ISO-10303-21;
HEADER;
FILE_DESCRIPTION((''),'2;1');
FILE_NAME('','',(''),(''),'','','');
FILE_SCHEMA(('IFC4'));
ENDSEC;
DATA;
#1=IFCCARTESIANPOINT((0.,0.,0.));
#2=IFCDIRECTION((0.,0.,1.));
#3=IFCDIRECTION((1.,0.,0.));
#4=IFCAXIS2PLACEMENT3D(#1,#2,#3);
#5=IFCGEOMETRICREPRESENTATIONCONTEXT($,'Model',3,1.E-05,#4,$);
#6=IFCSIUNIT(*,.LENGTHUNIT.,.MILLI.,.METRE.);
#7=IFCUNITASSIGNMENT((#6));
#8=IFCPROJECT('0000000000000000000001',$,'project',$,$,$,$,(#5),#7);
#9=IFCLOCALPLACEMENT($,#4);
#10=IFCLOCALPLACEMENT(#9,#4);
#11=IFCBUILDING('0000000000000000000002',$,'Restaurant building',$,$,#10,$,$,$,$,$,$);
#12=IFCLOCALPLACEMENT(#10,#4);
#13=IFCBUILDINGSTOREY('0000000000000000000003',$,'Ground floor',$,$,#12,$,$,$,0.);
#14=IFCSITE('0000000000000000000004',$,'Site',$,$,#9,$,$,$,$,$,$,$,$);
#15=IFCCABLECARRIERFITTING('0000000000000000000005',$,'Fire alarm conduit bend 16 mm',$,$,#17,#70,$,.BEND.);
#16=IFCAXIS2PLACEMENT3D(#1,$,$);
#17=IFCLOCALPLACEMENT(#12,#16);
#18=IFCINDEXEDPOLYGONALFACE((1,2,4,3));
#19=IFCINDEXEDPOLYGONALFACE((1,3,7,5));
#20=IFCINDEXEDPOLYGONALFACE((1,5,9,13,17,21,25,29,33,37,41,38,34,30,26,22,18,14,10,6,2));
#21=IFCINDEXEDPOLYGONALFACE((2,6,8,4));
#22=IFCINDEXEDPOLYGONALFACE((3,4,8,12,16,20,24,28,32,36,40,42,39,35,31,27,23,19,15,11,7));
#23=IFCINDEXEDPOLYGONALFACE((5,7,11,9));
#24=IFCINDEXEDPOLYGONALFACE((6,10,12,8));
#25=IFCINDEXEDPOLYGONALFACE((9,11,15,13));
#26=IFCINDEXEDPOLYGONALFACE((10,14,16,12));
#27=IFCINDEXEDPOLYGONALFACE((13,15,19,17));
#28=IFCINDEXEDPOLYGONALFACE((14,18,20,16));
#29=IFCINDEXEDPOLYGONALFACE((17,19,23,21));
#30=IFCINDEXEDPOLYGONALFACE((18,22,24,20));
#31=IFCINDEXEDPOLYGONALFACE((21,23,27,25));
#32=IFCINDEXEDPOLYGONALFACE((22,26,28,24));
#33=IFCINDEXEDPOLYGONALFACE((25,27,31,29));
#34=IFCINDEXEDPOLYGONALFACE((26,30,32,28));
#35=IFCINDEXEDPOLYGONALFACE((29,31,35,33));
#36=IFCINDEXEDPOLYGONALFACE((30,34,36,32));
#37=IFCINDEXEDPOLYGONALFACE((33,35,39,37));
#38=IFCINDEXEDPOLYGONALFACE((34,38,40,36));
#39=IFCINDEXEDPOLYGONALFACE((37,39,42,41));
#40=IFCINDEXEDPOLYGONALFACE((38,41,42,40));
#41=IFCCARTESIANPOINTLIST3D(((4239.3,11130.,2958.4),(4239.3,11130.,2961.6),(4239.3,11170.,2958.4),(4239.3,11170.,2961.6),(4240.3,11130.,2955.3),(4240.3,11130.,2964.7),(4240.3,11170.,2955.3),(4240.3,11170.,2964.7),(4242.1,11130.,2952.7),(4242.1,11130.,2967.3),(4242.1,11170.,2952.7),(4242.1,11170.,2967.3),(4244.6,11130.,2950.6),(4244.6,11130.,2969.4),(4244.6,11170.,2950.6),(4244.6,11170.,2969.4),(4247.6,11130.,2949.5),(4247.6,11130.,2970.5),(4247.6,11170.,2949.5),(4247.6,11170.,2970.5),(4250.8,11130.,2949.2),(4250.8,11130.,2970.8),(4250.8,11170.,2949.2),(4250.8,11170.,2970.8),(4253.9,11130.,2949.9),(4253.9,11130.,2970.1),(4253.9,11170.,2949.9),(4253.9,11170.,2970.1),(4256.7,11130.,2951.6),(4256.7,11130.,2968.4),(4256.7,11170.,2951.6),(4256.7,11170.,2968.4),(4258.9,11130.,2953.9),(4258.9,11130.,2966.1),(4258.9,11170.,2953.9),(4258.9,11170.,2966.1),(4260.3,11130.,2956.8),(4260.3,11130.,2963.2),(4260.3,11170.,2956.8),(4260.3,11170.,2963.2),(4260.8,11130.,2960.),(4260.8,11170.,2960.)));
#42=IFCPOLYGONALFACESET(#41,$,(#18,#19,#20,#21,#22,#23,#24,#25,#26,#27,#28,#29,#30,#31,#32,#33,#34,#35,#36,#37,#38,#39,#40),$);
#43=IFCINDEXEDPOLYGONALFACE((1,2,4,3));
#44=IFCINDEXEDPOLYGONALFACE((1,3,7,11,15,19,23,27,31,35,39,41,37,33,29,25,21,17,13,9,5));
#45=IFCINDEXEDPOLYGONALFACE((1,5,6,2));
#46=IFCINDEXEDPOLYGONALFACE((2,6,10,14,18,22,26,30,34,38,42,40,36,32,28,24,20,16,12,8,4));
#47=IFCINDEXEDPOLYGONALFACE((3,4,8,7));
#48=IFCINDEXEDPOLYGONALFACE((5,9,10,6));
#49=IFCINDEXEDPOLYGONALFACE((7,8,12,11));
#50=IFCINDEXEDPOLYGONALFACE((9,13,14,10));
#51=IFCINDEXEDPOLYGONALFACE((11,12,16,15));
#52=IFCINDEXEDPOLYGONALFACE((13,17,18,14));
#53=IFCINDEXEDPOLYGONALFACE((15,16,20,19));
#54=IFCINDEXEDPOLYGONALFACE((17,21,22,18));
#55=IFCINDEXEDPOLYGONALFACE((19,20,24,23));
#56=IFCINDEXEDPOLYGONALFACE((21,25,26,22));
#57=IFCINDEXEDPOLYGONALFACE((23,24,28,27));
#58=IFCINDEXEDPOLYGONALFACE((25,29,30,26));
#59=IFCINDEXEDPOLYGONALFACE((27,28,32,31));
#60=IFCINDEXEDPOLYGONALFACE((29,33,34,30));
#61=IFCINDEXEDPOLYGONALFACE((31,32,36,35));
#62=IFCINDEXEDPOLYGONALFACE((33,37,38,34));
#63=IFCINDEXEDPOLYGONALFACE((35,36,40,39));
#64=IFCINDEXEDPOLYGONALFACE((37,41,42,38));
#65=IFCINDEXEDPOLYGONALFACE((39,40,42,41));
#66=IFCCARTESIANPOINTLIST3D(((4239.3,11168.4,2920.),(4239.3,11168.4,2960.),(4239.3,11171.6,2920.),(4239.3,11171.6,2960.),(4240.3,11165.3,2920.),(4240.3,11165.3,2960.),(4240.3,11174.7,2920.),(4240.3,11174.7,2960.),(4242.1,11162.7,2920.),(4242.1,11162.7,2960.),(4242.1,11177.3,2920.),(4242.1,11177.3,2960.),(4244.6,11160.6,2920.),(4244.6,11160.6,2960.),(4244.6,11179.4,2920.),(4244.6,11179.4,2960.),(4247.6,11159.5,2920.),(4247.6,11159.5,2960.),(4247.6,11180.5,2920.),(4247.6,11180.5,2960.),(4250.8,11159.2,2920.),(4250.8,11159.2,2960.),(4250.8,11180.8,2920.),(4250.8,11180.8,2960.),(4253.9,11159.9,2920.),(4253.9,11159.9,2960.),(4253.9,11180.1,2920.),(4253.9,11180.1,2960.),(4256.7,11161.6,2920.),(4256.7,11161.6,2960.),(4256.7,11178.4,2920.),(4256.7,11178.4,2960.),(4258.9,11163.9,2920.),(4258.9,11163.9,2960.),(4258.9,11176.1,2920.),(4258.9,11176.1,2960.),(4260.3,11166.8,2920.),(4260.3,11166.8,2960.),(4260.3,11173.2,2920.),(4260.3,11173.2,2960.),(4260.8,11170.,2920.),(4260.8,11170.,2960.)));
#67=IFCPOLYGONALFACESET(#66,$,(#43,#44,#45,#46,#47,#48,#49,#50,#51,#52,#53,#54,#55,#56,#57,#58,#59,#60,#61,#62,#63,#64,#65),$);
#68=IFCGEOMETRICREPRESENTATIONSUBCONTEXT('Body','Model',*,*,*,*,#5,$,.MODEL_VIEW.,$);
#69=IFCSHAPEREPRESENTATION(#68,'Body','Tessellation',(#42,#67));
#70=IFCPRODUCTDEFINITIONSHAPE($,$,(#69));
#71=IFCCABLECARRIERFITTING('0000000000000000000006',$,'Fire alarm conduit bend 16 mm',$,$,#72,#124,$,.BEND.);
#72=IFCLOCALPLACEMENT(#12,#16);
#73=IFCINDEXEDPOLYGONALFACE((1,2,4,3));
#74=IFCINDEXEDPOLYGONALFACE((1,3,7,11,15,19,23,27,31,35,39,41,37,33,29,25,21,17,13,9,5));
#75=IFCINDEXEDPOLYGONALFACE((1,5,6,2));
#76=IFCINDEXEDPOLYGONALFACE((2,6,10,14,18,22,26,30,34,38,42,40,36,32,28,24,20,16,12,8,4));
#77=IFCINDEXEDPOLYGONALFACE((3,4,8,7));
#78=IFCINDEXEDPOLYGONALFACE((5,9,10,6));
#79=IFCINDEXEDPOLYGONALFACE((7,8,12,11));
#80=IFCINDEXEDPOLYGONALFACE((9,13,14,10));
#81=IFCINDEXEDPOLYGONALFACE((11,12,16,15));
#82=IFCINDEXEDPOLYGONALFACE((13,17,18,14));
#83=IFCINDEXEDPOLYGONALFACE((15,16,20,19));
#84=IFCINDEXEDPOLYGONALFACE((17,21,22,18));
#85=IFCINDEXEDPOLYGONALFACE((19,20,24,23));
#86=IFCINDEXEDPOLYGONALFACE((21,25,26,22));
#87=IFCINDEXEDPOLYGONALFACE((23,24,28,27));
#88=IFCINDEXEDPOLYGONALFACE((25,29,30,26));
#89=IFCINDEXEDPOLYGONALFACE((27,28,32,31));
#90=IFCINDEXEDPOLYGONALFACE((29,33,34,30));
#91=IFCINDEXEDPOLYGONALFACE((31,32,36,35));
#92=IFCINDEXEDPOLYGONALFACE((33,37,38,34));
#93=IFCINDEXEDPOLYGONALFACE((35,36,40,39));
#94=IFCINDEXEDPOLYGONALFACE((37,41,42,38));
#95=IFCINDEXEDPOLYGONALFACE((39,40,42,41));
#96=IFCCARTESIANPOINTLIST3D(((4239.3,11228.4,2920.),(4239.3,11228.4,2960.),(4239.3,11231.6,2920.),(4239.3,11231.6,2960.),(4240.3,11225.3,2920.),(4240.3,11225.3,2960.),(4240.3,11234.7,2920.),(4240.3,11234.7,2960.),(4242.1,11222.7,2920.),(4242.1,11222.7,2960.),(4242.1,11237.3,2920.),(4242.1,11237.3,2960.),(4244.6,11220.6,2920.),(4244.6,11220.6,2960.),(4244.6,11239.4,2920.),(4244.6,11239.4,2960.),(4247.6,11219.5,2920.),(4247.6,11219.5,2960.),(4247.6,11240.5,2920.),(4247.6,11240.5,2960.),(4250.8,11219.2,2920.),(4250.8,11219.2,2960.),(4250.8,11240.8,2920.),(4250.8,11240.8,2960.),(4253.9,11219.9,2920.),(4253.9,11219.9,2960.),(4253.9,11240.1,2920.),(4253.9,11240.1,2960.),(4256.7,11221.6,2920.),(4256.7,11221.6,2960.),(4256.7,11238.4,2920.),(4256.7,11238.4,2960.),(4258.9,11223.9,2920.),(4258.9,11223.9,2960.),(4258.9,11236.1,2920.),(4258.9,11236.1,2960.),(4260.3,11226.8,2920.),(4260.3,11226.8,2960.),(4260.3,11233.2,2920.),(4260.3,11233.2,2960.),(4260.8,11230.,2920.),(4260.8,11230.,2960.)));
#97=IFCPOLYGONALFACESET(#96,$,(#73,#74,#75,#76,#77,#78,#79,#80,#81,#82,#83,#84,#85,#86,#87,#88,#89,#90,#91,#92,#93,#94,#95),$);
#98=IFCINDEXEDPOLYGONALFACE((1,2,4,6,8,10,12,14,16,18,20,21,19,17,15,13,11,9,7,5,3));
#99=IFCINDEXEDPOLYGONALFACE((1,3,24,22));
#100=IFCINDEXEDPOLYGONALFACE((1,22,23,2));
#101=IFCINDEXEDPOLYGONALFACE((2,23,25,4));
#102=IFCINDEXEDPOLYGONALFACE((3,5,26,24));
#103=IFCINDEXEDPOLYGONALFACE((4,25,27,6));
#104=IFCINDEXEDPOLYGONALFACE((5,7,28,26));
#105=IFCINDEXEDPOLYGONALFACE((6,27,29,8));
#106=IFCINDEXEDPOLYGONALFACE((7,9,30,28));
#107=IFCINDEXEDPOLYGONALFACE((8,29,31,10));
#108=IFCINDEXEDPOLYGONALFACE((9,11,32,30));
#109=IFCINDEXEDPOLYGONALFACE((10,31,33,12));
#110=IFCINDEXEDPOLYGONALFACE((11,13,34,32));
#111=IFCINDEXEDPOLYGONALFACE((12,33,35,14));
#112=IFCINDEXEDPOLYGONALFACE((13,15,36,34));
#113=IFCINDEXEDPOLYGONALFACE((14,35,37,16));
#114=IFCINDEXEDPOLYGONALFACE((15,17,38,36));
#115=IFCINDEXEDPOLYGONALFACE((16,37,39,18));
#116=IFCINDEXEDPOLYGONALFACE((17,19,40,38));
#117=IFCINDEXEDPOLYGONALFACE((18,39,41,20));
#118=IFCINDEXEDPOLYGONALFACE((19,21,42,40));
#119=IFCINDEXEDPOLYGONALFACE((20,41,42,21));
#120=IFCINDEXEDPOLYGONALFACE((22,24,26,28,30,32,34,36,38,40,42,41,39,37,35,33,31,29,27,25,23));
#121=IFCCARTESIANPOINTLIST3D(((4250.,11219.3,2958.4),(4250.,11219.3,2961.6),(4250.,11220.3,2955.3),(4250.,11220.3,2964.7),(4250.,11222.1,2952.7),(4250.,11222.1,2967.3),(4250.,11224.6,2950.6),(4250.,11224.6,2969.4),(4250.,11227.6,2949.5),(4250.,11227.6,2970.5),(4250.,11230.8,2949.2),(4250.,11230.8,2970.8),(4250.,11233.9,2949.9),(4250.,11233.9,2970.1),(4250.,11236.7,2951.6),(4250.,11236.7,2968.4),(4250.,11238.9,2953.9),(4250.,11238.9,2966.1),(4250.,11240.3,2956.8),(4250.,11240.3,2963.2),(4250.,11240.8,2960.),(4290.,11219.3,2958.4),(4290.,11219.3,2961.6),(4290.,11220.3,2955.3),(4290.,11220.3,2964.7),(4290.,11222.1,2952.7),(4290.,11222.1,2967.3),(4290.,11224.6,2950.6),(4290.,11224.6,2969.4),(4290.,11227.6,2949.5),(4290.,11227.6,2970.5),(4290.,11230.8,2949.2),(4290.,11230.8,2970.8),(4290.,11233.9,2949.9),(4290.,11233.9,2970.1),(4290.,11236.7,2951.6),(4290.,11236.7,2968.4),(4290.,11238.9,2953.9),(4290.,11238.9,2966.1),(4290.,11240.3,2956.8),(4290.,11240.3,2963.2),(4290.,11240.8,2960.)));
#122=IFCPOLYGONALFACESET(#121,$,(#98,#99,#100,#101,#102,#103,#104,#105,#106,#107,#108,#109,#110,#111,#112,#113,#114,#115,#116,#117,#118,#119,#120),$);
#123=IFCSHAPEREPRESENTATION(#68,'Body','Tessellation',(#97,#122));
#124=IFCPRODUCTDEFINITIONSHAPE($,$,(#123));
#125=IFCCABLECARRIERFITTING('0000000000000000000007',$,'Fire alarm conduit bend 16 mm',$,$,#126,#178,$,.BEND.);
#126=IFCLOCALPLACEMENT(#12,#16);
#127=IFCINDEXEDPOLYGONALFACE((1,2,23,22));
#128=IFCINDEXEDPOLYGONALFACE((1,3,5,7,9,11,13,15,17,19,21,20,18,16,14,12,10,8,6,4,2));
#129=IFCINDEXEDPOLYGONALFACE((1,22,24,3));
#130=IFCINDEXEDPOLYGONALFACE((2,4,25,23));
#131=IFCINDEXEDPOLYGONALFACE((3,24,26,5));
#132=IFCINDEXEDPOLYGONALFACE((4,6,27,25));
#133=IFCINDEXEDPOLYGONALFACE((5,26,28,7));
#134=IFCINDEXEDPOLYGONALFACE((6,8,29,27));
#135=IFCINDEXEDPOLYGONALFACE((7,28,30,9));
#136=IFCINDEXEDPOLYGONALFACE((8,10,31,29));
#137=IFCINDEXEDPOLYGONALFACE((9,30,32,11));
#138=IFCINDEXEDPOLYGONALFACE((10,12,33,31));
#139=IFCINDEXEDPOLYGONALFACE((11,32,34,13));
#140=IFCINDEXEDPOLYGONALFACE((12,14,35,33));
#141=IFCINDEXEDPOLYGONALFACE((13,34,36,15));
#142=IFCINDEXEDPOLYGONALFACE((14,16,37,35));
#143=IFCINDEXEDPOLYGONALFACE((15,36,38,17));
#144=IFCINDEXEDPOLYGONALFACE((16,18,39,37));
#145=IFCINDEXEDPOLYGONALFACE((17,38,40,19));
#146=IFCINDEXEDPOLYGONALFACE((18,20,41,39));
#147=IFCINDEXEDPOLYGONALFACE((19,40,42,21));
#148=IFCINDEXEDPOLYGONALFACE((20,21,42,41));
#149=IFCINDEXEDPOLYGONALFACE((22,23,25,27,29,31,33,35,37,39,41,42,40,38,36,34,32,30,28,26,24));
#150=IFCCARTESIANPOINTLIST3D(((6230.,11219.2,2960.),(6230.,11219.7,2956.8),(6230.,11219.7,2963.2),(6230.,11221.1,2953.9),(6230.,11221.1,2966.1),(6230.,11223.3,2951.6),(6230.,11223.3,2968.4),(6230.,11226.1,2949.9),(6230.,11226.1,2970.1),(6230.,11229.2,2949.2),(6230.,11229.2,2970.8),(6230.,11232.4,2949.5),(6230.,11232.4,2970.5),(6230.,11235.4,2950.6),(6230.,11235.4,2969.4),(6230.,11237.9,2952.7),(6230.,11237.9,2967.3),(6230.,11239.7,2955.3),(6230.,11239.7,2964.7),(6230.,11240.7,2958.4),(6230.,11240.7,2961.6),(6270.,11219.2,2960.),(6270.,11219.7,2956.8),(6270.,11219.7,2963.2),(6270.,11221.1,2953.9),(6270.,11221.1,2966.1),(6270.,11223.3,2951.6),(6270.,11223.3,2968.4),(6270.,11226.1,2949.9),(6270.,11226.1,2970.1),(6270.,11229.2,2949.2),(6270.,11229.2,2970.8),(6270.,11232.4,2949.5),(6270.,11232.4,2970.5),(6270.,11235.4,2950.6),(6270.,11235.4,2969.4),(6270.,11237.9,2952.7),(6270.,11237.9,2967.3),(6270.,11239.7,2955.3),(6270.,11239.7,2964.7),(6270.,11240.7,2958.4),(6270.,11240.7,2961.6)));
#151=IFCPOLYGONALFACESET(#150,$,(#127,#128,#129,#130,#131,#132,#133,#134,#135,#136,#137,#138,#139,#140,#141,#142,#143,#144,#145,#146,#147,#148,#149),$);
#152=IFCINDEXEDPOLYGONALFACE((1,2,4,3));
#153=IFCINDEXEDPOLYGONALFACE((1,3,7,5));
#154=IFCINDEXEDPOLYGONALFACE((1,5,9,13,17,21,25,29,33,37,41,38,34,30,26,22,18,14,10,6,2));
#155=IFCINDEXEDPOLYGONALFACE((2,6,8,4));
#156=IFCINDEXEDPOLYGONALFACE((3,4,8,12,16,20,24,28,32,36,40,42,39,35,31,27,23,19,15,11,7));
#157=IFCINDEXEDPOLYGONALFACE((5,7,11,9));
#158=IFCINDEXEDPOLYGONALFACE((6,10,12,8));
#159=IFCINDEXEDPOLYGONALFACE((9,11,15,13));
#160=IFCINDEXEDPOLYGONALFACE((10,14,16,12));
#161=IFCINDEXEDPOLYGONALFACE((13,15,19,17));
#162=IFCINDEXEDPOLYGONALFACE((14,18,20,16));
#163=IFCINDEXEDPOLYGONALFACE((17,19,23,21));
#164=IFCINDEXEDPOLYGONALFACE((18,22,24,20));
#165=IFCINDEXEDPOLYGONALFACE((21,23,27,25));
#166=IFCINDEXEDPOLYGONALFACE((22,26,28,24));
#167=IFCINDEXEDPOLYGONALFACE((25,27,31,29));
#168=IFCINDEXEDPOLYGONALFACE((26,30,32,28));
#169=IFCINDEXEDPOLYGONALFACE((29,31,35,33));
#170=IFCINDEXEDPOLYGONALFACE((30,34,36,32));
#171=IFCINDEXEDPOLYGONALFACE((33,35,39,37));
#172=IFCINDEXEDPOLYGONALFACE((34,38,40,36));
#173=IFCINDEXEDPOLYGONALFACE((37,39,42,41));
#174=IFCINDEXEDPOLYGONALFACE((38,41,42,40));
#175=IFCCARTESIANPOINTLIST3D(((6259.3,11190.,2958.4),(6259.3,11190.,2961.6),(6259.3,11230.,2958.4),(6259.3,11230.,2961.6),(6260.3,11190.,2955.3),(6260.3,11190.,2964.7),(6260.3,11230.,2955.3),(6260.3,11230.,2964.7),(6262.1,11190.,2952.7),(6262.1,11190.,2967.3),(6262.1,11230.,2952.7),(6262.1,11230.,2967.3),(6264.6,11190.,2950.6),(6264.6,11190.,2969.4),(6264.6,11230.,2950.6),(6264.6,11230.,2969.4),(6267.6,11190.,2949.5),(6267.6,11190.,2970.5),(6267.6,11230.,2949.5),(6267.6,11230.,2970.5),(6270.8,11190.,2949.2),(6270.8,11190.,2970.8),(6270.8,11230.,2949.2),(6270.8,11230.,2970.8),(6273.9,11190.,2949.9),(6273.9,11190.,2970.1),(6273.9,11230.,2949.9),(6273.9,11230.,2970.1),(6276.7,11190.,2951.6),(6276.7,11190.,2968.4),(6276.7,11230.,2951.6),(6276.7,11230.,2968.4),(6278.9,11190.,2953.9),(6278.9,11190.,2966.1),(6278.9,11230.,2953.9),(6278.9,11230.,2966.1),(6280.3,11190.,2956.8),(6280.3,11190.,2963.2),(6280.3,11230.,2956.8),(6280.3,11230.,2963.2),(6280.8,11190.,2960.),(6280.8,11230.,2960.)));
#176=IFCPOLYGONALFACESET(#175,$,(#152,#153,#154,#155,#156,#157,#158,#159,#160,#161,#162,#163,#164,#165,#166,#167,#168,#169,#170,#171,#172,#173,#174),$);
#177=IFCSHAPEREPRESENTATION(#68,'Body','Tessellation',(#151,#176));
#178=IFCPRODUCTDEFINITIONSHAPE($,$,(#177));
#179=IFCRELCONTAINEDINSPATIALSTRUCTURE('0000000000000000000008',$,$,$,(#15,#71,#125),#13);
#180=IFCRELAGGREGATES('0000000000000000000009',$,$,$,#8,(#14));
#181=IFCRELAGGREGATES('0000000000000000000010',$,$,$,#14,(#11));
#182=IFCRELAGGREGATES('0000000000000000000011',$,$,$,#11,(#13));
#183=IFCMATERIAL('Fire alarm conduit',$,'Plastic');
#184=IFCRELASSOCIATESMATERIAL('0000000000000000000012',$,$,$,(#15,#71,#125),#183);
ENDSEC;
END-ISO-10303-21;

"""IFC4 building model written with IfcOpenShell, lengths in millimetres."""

from ifc_helpers import new_model, si_unit, frame, origin_with_axes, origin_2d, place, context, subcontext, project, spatial, circle, extrude, material, element, save


model = new_model("IFC4")

# Units and contexts
model_context = context("Model", 3, precision=1e-05, world=origin_with_axes())
body_context = subcontext(model_context, "Body", "Model", "MODEL_VIEW")
ifc_project = project(units=[si_unit("LENGTHUNIT", "METRE", prefix="MILLI")], contexts=[model_context])

# Site, building, storey
site_placement = place(None, origin_with_axes())
site = spatial("IfcSite", under=ifc_project, at=site_placement, Name="Site")
building_placement = place(site_placement, origin_with_axes())
building = spatial("IfcBuilding", under=site, at=building_placement, Name="Restaurant building")
storey_placement = place(building_placement, origin_with_axes())
storey = spatial("IfcBuildingStorey", under=building, at=storey_placement, Name="Ground floor", Elevation=0.0)

# Shared definitions
ifc_material_1 = material(Name="Fire alarm conduit", Category="Plastic")

# Cable carrier fittings
cable_carrier_fitting_1_placement = place(storey_placement, frame((4250.0, 11170.0, 2960.0)))
element("IfcCableCarrierFitting", 1, at=cable_carrier_fitting_1_placement, inside=storey, material=ifc_material_1, Name="Fire alarm conduit bend 16 mm", PredefinedType="BEND", context=body_context, shape_type="SweptSolid", body=[
    extrude(circle(Radius=10.8, at=origin_2d()), frame((0.0, 0.0, 0.0), z_axis=(0.0, -1.0, 0.0), x_axis=(1.0, 0.0, 0.0)), (0.0, 0.0, 1.0), 40.0),
    extrude(circle(Radius=10.8, at=origin_2d()), frame((0.0, 0.0, 0.0), z_axis=(0.0, 0.0, -1.0), x_axis=(1.0, 0.0, 0.0)), (0.0, 0.0, 1.0), 40.0),
])
cable_carrier_fitting_2_placement = place(storey_placement, frame((4250.0, 11230.0, 2960.0)))
element("IfcCableCarrierFitting", 2, at=cable_carrier_fitting_2_placement, inside=storey, material=ifc_material_1, Name="Fire alarm conduit bend 16 mm", PredefinedType="BEND", context=body_context, shape_type="SweptSolid", body=[
    extrude(circle(Radius=10.8, at=origin_2d()), frame((0.0, 0.0, 0.0), z_axis=(0.0, 0.0, -1.0), x_axis=(1.0, 0.0, 0.0)), (0.0, 0.0, 1.0), 40.0),
    extrude(circle(Radius=10.8, at=origin_2d()), frame((0.0, 0.0, 0.0), z_axis=(1.0, 0.0, 0.0), x_axis=(0.0, 1.0, 0.0)), (0.0, 0.0, 1.0), 40.0),
])
cable_carrier_fitting_3_placement = place(storey_placement, frame((6270.0, 11230.0, 2960.0)))
element("IfcCableCarrierFitting", 3, at=cable_carrier_fitting_3_placement, inside=storey, material=ifc_material_1, Name="Fire alarm conduit bend 16 mm", PredefinedType="BEND", context=body_context, shape_type="SweptSolid", body=[
    extrude(circle(Radius=10.8, at=origin_2d()), frame((0.0, 0.0, 0.0), z_axis=(-1.0, 0.0, 0.0), x_axis=(0.0, -1.0, 0.0)), (0.0, 0.0, 1.0), 40.0),
    extrude(circle(Radius=10.8, at=origin_2d()), frame((0.0, 0.0, 0.0), z_axis=(0.0, -1.0, 0.0), x_axis=(1.0, 0.0, 0.0)), (0.0, 0.0, 1.0), 40.0),
])

save(model, "model.ifc")
